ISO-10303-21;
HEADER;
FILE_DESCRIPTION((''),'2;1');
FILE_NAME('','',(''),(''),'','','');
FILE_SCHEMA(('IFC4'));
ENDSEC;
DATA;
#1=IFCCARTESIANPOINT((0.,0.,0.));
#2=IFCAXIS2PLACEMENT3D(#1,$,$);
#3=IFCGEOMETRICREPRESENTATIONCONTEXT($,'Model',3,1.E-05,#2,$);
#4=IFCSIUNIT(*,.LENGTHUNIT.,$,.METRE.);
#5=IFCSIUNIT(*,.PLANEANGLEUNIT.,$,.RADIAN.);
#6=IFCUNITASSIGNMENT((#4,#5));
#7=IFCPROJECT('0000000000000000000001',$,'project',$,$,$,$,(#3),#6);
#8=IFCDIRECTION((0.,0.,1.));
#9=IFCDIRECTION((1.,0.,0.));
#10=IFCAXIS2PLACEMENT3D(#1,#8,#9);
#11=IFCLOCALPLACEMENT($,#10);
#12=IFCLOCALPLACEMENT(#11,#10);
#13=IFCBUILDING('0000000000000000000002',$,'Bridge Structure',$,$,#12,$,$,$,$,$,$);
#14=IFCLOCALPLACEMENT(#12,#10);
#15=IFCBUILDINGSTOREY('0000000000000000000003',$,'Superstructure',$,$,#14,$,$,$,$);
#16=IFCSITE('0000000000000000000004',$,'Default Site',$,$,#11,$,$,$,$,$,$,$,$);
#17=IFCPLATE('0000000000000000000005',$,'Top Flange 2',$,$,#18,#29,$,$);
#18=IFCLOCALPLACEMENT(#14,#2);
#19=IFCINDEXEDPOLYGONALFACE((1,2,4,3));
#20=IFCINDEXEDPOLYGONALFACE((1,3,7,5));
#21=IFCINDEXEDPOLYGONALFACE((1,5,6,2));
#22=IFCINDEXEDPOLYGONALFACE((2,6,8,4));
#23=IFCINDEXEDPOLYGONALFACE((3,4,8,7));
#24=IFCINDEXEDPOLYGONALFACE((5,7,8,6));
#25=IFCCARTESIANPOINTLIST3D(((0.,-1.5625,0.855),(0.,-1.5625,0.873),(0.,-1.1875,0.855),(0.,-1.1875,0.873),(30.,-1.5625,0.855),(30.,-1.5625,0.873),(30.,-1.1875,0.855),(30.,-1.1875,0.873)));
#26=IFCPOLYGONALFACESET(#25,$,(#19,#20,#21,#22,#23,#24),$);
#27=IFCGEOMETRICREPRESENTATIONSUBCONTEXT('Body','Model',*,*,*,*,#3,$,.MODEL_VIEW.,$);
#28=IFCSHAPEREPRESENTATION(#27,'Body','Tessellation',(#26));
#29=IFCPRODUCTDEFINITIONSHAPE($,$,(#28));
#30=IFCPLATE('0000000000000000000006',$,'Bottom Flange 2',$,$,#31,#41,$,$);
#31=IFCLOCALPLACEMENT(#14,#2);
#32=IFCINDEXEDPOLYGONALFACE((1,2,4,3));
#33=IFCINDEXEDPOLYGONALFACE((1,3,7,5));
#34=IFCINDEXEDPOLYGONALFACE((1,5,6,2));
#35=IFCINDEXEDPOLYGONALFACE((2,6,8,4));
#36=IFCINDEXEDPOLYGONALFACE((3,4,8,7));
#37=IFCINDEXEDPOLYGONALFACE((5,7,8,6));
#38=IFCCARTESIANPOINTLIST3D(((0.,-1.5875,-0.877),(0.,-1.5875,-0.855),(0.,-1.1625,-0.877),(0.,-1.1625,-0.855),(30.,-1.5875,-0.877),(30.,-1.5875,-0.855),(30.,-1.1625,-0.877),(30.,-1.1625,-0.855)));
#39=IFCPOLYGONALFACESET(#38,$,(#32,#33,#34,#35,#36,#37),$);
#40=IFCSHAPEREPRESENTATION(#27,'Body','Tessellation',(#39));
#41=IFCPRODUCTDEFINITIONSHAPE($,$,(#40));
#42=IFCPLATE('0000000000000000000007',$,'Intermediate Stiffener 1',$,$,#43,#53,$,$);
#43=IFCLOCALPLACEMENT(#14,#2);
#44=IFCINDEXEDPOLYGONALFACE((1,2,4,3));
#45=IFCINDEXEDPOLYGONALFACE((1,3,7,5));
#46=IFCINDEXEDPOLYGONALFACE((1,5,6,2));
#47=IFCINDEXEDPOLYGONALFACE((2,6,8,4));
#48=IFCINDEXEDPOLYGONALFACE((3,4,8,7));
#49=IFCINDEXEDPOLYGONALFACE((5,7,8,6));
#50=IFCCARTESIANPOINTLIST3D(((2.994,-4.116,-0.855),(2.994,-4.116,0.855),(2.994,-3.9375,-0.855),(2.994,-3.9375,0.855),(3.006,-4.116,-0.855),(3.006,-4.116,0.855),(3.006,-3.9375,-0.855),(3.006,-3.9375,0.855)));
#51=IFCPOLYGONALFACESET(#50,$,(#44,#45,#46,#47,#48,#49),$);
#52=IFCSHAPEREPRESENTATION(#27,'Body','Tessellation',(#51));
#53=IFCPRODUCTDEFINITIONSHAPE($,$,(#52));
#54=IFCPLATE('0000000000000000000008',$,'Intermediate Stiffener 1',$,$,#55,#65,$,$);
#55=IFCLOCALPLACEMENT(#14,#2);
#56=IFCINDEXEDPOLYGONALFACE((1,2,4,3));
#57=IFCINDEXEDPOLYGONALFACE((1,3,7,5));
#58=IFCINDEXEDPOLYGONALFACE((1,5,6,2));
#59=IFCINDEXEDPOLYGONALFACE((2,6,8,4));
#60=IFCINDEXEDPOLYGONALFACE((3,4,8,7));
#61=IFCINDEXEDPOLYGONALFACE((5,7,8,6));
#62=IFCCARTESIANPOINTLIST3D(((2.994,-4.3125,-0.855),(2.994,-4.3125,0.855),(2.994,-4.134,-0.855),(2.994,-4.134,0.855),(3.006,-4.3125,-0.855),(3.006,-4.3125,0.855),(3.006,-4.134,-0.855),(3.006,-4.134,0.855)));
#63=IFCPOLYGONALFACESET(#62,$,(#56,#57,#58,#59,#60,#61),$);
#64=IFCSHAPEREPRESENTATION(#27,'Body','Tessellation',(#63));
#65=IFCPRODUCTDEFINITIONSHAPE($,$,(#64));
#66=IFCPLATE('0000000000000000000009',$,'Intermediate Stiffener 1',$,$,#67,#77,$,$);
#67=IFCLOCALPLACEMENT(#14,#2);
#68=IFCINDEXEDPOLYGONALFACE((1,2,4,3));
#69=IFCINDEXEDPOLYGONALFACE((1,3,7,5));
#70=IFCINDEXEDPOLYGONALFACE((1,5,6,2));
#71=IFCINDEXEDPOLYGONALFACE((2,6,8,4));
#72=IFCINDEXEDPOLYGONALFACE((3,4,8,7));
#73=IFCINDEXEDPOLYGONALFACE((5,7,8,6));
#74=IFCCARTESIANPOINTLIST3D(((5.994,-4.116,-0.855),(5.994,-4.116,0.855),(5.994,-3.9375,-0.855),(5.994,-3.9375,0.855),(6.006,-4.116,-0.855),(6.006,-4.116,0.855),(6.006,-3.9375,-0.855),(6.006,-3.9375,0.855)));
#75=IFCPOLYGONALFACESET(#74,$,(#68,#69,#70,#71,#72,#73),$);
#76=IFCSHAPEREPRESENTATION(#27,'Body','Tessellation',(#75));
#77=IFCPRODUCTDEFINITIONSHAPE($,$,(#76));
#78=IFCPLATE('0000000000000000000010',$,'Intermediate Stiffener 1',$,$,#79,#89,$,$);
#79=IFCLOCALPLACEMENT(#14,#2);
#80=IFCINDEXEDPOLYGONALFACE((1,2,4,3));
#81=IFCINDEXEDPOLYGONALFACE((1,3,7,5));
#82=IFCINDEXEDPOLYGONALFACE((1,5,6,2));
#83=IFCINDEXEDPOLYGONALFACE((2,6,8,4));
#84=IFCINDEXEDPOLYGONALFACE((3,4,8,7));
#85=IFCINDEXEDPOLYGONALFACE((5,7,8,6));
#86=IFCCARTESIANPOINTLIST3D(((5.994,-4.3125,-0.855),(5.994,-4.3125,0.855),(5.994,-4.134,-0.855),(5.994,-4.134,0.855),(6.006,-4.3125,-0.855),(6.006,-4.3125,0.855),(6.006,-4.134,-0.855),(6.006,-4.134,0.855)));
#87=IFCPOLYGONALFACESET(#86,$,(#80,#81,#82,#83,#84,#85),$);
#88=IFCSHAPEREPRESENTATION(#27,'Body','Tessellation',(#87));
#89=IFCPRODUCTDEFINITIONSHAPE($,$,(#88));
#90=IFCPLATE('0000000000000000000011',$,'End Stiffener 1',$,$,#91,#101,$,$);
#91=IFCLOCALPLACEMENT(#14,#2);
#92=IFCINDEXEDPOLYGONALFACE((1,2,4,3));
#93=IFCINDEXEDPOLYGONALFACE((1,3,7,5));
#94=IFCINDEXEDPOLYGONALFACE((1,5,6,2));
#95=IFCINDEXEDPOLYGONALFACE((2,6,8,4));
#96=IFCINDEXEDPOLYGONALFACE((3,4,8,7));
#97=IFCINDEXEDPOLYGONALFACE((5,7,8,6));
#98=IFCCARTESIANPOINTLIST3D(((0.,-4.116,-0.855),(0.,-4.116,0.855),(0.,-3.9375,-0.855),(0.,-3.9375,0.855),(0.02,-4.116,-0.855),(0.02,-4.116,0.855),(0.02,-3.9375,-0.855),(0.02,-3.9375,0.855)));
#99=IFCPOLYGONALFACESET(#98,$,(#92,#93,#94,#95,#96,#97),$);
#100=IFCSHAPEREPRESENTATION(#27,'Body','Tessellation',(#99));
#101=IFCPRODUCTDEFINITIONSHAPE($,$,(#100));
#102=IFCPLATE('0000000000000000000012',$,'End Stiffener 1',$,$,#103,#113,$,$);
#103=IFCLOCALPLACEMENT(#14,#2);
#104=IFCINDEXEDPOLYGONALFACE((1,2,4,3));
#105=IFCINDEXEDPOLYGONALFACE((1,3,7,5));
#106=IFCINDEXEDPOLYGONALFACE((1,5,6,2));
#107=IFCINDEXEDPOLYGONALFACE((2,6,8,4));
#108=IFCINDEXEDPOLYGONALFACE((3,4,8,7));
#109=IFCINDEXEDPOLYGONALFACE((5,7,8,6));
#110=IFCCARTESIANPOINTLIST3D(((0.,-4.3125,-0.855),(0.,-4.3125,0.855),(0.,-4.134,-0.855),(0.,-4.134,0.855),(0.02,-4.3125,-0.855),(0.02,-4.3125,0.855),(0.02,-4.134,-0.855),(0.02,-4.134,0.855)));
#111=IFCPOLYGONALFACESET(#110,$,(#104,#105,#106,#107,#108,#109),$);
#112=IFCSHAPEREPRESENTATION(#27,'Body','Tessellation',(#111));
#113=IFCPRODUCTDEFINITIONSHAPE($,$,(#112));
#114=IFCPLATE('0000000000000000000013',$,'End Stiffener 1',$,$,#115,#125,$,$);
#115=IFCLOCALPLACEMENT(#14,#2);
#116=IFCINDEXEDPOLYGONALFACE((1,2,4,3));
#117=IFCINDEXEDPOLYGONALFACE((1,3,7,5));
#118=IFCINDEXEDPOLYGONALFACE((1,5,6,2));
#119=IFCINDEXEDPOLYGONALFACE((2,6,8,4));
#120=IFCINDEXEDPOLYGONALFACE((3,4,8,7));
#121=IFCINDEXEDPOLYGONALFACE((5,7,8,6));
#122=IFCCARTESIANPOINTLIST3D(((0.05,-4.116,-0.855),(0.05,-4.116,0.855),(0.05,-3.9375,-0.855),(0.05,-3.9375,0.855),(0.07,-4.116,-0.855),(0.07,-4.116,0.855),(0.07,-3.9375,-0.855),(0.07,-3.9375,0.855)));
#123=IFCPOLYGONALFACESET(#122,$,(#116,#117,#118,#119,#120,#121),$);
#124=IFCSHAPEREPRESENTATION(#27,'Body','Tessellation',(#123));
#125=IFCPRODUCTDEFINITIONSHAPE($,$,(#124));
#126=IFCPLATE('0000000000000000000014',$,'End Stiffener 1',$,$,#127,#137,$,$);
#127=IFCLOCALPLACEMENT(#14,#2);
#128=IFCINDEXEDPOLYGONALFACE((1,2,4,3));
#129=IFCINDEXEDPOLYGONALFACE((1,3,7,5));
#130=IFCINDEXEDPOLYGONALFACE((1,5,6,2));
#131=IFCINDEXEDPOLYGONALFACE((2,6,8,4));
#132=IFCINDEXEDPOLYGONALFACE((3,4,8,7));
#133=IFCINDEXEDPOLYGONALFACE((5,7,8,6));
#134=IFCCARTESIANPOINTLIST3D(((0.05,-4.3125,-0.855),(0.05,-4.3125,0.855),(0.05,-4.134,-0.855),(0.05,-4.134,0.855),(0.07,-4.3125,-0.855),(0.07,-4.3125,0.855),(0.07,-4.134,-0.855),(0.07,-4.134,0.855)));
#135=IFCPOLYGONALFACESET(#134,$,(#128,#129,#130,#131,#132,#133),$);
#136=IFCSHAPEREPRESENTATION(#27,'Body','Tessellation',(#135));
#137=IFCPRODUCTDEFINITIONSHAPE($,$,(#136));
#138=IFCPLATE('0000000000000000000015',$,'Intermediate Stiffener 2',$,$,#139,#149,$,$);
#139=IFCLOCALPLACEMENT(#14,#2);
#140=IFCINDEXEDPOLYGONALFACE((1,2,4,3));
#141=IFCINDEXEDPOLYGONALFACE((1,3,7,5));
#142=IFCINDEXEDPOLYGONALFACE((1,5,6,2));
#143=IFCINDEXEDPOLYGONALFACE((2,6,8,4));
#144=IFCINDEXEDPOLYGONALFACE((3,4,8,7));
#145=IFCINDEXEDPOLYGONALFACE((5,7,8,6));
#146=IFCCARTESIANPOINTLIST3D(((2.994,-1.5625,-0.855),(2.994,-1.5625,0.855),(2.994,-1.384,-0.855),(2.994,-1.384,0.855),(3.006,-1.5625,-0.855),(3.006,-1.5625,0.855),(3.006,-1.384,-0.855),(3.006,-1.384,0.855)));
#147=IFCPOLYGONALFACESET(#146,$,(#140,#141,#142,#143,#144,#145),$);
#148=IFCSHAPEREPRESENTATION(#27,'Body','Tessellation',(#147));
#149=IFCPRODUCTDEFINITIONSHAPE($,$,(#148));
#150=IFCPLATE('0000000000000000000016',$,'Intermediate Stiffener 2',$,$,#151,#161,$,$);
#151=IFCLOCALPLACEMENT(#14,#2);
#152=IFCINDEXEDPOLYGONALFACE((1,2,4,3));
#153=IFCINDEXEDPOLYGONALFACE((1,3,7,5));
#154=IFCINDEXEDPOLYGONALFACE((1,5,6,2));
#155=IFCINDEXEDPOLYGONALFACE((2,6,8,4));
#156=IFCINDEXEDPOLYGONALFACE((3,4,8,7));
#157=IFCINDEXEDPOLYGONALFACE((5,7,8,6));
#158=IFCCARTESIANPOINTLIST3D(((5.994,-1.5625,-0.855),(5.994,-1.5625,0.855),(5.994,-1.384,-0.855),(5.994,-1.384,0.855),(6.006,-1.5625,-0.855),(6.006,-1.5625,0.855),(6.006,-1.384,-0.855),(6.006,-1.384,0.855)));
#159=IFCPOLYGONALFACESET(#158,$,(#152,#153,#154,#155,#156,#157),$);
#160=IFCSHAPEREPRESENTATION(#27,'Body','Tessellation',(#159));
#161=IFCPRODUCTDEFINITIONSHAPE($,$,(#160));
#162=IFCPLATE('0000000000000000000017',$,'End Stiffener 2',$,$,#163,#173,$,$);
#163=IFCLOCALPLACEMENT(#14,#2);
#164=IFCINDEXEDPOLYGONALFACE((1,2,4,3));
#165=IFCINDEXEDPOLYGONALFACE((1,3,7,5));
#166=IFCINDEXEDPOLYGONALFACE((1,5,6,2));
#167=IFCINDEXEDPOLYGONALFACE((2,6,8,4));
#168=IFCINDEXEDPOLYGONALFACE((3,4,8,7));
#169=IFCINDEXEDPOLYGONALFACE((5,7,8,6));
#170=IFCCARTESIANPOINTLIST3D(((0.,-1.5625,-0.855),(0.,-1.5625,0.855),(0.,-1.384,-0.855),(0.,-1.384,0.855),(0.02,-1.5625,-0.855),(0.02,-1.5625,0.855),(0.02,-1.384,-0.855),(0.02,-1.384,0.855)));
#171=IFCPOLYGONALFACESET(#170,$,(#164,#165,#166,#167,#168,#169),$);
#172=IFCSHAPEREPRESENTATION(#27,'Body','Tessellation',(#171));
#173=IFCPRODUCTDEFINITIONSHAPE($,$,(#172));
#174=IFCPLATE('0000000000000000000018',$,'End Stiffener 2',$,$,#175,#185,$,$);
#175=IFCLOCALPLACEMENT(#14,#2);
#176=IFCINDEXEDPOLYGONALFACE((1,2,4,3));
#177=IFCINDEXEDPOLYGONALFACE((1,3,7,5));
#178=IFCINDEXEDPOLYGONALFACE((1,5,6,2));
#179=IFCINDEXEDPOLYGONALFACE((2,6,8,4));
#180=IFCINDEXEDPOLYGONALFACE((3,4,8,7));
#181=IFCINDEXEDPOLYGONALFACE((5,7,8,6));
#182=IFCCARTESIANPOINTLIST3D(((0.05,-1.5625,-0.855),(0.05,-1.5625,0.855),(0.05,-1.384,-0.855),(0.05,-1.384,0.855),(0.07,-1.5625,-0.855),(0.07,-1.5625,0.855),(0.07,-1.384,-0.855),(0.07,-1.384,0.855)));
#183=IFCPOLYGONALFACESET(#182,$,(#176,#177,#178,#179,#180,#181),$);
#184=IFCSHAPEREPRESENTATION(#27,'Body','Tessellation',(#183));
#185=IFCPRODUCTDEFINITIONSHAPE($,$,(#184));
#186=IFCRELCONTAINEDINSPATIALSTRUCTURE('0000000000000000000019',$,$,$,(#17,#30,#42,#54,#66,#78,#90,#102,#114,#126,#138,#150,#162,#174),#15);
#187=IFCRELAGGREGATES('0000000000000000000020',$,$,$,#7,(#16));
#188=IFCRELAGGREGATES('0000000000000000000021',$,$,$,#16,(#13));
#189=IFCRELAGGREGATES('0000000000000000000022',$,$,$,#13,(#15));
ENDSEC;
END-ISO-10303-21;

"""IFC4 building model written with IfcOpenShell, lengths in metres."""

from ifc_helpers import new_model, si_unit, frame, origin, origin_with_axes, origin_2d_with_axis, place, context, subcontext, project, spatial, rectangle, extrude, element, save


model = new_model("IFC4")

# Units and contexts
model_context = context("Model", 3, precision=1e-05, world=origin())
body_context = subcontext(model_context, "Body", "Model", "MODEL_VIEW")
ifc_project = project(units=[si_unit("LENGTHUNIT", "METRE"), si_unit("PLANEANGLEUNIT", "RADIAN")], contexts=[model_context])

# Site, building, storey
site_placement = place(None, origin_with_axes())
site = spatial("IfcSite", under=ifc_project, at=site_placement, Name="Default Site")
building_placement = place(site_placement, origin_with_axes())
building = spatial("IfcBuilding", under=site, at=building_placement, Name="Bridge Structure")
storey_placement = place(building_placement, origin_with_axes())
storey = spatial("IfcBuildingStorey", under=building, at=storey_placement, Name="Superstructure")

# Plates
plate_1_placement = place(storey_placement, frame((0.0, -1.375, 0.864), z_axis=(1.0, 0.0, 0.0), x_axis=(0.0, 1.0, 0.0)))
element("IfcPlate", 1, at=plate_1_placement, inside=storey, Name="Top Flange 2", context=body_context, shape_type="SweptSolid", body=[
    extrude(rectangle(XDim=0.375, YDim=0.018, at=origin_2d_with_axis()), origin_with_axes(), (0.0, 0.0, 1.0), 30.0),
])
plate_2_placement = place(storey_placement, frame((0.0, -1.375, -0.866), z_axis=(1.0, 0.0, 0.0), x_axis=(0.0, 1.0, 0.0)))
element("IfcPlate", 2, at=plate_2_placement, inside=storey, Name="Bottom Flange 2", context=body_context, shape_type="SweptSolid", body=[
    extrude(rectangle(XDim=0.425, YDim=0.022, at=origin_2d_with_axis()), origin_with_axes(), (0.0, 0.0, 1.0), 30.0),
])
for number, where, z_axis, x_axis, name in (
    (3, (3.0, -4.0267, -0.855), (0.0, 0.0, 1.0), (1.0, 0.0, 0.0), "Intermediate Stiffener 1"),
    (4, (3.0, -4.2233, -0.855), (0.0, 0.0, 1.0), (1.0, 0.0, 0.0), "Intermediate Stiffener 1"),
    (5, (6.0, -4.0267, -0.855), (0.0, 0.0, 1.0), (1.0, 0.0, 0.0), "Intermediate Stiffener 1"),
    (6, (6.0, -4.2233, -0.855), (0.0, 0.0, 1.0), (1.0, 0.0, 0.0), "Intermediate Stiffener 1"),
):
    element("IfcPlate", number, at=place(storey_placement, frame(where, z_axis=z_axis, x_axis=x_axis)), inside=storey, Name=name, context=body_context, shape_type="SweptSolid", body=[
        extrude(rectangle(XDim=0.012, YDim=0.1785, at=origin_2d_with_axis()), origin_with_axes(), (0.0, 0.0, 1.0), 1.71),
    ])
for number, where, z_axis, x_axis, name in (
    (7, (0.01, -4.0267, -0.855), (0.0, 0.0, 1.0), (1.0, 0.0, 0.0), "End Stiffener 1"),
    (8, (0.01, -4.2233, -0.855), (0.0, 0.0, 1.0), (1.0, 0.0, 0.0), "End Stiffener 1"),
    (9, (0.06, -4.0267, -0.855), (0.0, 0.0, 1.0), (1.0, 0.0, 0.0), "End Stiffener 1"),
    (10, (0.06, -4.2233, -0.855), (0.0, 0.0, 1.0), (1.0, 0.0, 0.0), "End Stiffener 1"),
):
    element("IfcPlate", number, at=place(storey_placement, frame(where, z_axis=z_axis, x_axis=x_axis)), inside=storey, Name=name, context=body_context, shape_type="SweptSolid", body=[
        extrude(rectangle(XDim=0.02, YDim=0.1785, at=origin_2d_with_axis()), origin_with_axes(), (0.0, 0.0, 1.0), 1.71),
    ])
for number, where, z_axis, x_axis, name in (
    (11, (3.0, -1.4732, -0.855), (0.0, 0.0, 1.0), (1.0, 0.0, 0.0), "Intermediate Stiffener 2"),
    (12, (6.0, -1.4732, -0.855), (0.0, 0.0, 1.0), (1.0, 0.0, 0.0), "Intermediate Stiffener 2"),
):
    element("IfcPlate", number, at=place(storey_placement, frame(where, z_axis=z_axis, x_axis=x_axis)), inside=storey, Name=name, context=body_context, shape_type="SweptSolid", body=[
        extrude(rectangle(XDim=0.012, YDim=0.1785, at=origin_2d_with_axis()), origin_with_axes(), (0.0, 0.0, 1.0), 1.71),
    ])
for number, where, z_axis, x_axis, name in (
    (13, (0.01, -1.4732, -0.855), (0.0, 0.0, 1.0), (1.0, 0.0, 0.0), "End Stiffener 2"),
    (14, (0.06, -1.4732, -0.855), (0.0, 0.0, 1.0), (1.0, 0.0, 0.0), "End Stiffener 2"),
):
    element("IfcPlate", number, at=place(storey_placement, frame(where, z_axis=z_axis, x_axis=x_axis)), inside=storey, Name=name, context=body_context, shape_type="SweptSolid", body=[
        extrude(rectangle(XDim=0.02, YDim=0.1785, at=origin_2d_with_axis()), origin_with_axes(), (0.0, 0.0, 1.0), 1.71),
    ])

save(model, "model.ifc")
